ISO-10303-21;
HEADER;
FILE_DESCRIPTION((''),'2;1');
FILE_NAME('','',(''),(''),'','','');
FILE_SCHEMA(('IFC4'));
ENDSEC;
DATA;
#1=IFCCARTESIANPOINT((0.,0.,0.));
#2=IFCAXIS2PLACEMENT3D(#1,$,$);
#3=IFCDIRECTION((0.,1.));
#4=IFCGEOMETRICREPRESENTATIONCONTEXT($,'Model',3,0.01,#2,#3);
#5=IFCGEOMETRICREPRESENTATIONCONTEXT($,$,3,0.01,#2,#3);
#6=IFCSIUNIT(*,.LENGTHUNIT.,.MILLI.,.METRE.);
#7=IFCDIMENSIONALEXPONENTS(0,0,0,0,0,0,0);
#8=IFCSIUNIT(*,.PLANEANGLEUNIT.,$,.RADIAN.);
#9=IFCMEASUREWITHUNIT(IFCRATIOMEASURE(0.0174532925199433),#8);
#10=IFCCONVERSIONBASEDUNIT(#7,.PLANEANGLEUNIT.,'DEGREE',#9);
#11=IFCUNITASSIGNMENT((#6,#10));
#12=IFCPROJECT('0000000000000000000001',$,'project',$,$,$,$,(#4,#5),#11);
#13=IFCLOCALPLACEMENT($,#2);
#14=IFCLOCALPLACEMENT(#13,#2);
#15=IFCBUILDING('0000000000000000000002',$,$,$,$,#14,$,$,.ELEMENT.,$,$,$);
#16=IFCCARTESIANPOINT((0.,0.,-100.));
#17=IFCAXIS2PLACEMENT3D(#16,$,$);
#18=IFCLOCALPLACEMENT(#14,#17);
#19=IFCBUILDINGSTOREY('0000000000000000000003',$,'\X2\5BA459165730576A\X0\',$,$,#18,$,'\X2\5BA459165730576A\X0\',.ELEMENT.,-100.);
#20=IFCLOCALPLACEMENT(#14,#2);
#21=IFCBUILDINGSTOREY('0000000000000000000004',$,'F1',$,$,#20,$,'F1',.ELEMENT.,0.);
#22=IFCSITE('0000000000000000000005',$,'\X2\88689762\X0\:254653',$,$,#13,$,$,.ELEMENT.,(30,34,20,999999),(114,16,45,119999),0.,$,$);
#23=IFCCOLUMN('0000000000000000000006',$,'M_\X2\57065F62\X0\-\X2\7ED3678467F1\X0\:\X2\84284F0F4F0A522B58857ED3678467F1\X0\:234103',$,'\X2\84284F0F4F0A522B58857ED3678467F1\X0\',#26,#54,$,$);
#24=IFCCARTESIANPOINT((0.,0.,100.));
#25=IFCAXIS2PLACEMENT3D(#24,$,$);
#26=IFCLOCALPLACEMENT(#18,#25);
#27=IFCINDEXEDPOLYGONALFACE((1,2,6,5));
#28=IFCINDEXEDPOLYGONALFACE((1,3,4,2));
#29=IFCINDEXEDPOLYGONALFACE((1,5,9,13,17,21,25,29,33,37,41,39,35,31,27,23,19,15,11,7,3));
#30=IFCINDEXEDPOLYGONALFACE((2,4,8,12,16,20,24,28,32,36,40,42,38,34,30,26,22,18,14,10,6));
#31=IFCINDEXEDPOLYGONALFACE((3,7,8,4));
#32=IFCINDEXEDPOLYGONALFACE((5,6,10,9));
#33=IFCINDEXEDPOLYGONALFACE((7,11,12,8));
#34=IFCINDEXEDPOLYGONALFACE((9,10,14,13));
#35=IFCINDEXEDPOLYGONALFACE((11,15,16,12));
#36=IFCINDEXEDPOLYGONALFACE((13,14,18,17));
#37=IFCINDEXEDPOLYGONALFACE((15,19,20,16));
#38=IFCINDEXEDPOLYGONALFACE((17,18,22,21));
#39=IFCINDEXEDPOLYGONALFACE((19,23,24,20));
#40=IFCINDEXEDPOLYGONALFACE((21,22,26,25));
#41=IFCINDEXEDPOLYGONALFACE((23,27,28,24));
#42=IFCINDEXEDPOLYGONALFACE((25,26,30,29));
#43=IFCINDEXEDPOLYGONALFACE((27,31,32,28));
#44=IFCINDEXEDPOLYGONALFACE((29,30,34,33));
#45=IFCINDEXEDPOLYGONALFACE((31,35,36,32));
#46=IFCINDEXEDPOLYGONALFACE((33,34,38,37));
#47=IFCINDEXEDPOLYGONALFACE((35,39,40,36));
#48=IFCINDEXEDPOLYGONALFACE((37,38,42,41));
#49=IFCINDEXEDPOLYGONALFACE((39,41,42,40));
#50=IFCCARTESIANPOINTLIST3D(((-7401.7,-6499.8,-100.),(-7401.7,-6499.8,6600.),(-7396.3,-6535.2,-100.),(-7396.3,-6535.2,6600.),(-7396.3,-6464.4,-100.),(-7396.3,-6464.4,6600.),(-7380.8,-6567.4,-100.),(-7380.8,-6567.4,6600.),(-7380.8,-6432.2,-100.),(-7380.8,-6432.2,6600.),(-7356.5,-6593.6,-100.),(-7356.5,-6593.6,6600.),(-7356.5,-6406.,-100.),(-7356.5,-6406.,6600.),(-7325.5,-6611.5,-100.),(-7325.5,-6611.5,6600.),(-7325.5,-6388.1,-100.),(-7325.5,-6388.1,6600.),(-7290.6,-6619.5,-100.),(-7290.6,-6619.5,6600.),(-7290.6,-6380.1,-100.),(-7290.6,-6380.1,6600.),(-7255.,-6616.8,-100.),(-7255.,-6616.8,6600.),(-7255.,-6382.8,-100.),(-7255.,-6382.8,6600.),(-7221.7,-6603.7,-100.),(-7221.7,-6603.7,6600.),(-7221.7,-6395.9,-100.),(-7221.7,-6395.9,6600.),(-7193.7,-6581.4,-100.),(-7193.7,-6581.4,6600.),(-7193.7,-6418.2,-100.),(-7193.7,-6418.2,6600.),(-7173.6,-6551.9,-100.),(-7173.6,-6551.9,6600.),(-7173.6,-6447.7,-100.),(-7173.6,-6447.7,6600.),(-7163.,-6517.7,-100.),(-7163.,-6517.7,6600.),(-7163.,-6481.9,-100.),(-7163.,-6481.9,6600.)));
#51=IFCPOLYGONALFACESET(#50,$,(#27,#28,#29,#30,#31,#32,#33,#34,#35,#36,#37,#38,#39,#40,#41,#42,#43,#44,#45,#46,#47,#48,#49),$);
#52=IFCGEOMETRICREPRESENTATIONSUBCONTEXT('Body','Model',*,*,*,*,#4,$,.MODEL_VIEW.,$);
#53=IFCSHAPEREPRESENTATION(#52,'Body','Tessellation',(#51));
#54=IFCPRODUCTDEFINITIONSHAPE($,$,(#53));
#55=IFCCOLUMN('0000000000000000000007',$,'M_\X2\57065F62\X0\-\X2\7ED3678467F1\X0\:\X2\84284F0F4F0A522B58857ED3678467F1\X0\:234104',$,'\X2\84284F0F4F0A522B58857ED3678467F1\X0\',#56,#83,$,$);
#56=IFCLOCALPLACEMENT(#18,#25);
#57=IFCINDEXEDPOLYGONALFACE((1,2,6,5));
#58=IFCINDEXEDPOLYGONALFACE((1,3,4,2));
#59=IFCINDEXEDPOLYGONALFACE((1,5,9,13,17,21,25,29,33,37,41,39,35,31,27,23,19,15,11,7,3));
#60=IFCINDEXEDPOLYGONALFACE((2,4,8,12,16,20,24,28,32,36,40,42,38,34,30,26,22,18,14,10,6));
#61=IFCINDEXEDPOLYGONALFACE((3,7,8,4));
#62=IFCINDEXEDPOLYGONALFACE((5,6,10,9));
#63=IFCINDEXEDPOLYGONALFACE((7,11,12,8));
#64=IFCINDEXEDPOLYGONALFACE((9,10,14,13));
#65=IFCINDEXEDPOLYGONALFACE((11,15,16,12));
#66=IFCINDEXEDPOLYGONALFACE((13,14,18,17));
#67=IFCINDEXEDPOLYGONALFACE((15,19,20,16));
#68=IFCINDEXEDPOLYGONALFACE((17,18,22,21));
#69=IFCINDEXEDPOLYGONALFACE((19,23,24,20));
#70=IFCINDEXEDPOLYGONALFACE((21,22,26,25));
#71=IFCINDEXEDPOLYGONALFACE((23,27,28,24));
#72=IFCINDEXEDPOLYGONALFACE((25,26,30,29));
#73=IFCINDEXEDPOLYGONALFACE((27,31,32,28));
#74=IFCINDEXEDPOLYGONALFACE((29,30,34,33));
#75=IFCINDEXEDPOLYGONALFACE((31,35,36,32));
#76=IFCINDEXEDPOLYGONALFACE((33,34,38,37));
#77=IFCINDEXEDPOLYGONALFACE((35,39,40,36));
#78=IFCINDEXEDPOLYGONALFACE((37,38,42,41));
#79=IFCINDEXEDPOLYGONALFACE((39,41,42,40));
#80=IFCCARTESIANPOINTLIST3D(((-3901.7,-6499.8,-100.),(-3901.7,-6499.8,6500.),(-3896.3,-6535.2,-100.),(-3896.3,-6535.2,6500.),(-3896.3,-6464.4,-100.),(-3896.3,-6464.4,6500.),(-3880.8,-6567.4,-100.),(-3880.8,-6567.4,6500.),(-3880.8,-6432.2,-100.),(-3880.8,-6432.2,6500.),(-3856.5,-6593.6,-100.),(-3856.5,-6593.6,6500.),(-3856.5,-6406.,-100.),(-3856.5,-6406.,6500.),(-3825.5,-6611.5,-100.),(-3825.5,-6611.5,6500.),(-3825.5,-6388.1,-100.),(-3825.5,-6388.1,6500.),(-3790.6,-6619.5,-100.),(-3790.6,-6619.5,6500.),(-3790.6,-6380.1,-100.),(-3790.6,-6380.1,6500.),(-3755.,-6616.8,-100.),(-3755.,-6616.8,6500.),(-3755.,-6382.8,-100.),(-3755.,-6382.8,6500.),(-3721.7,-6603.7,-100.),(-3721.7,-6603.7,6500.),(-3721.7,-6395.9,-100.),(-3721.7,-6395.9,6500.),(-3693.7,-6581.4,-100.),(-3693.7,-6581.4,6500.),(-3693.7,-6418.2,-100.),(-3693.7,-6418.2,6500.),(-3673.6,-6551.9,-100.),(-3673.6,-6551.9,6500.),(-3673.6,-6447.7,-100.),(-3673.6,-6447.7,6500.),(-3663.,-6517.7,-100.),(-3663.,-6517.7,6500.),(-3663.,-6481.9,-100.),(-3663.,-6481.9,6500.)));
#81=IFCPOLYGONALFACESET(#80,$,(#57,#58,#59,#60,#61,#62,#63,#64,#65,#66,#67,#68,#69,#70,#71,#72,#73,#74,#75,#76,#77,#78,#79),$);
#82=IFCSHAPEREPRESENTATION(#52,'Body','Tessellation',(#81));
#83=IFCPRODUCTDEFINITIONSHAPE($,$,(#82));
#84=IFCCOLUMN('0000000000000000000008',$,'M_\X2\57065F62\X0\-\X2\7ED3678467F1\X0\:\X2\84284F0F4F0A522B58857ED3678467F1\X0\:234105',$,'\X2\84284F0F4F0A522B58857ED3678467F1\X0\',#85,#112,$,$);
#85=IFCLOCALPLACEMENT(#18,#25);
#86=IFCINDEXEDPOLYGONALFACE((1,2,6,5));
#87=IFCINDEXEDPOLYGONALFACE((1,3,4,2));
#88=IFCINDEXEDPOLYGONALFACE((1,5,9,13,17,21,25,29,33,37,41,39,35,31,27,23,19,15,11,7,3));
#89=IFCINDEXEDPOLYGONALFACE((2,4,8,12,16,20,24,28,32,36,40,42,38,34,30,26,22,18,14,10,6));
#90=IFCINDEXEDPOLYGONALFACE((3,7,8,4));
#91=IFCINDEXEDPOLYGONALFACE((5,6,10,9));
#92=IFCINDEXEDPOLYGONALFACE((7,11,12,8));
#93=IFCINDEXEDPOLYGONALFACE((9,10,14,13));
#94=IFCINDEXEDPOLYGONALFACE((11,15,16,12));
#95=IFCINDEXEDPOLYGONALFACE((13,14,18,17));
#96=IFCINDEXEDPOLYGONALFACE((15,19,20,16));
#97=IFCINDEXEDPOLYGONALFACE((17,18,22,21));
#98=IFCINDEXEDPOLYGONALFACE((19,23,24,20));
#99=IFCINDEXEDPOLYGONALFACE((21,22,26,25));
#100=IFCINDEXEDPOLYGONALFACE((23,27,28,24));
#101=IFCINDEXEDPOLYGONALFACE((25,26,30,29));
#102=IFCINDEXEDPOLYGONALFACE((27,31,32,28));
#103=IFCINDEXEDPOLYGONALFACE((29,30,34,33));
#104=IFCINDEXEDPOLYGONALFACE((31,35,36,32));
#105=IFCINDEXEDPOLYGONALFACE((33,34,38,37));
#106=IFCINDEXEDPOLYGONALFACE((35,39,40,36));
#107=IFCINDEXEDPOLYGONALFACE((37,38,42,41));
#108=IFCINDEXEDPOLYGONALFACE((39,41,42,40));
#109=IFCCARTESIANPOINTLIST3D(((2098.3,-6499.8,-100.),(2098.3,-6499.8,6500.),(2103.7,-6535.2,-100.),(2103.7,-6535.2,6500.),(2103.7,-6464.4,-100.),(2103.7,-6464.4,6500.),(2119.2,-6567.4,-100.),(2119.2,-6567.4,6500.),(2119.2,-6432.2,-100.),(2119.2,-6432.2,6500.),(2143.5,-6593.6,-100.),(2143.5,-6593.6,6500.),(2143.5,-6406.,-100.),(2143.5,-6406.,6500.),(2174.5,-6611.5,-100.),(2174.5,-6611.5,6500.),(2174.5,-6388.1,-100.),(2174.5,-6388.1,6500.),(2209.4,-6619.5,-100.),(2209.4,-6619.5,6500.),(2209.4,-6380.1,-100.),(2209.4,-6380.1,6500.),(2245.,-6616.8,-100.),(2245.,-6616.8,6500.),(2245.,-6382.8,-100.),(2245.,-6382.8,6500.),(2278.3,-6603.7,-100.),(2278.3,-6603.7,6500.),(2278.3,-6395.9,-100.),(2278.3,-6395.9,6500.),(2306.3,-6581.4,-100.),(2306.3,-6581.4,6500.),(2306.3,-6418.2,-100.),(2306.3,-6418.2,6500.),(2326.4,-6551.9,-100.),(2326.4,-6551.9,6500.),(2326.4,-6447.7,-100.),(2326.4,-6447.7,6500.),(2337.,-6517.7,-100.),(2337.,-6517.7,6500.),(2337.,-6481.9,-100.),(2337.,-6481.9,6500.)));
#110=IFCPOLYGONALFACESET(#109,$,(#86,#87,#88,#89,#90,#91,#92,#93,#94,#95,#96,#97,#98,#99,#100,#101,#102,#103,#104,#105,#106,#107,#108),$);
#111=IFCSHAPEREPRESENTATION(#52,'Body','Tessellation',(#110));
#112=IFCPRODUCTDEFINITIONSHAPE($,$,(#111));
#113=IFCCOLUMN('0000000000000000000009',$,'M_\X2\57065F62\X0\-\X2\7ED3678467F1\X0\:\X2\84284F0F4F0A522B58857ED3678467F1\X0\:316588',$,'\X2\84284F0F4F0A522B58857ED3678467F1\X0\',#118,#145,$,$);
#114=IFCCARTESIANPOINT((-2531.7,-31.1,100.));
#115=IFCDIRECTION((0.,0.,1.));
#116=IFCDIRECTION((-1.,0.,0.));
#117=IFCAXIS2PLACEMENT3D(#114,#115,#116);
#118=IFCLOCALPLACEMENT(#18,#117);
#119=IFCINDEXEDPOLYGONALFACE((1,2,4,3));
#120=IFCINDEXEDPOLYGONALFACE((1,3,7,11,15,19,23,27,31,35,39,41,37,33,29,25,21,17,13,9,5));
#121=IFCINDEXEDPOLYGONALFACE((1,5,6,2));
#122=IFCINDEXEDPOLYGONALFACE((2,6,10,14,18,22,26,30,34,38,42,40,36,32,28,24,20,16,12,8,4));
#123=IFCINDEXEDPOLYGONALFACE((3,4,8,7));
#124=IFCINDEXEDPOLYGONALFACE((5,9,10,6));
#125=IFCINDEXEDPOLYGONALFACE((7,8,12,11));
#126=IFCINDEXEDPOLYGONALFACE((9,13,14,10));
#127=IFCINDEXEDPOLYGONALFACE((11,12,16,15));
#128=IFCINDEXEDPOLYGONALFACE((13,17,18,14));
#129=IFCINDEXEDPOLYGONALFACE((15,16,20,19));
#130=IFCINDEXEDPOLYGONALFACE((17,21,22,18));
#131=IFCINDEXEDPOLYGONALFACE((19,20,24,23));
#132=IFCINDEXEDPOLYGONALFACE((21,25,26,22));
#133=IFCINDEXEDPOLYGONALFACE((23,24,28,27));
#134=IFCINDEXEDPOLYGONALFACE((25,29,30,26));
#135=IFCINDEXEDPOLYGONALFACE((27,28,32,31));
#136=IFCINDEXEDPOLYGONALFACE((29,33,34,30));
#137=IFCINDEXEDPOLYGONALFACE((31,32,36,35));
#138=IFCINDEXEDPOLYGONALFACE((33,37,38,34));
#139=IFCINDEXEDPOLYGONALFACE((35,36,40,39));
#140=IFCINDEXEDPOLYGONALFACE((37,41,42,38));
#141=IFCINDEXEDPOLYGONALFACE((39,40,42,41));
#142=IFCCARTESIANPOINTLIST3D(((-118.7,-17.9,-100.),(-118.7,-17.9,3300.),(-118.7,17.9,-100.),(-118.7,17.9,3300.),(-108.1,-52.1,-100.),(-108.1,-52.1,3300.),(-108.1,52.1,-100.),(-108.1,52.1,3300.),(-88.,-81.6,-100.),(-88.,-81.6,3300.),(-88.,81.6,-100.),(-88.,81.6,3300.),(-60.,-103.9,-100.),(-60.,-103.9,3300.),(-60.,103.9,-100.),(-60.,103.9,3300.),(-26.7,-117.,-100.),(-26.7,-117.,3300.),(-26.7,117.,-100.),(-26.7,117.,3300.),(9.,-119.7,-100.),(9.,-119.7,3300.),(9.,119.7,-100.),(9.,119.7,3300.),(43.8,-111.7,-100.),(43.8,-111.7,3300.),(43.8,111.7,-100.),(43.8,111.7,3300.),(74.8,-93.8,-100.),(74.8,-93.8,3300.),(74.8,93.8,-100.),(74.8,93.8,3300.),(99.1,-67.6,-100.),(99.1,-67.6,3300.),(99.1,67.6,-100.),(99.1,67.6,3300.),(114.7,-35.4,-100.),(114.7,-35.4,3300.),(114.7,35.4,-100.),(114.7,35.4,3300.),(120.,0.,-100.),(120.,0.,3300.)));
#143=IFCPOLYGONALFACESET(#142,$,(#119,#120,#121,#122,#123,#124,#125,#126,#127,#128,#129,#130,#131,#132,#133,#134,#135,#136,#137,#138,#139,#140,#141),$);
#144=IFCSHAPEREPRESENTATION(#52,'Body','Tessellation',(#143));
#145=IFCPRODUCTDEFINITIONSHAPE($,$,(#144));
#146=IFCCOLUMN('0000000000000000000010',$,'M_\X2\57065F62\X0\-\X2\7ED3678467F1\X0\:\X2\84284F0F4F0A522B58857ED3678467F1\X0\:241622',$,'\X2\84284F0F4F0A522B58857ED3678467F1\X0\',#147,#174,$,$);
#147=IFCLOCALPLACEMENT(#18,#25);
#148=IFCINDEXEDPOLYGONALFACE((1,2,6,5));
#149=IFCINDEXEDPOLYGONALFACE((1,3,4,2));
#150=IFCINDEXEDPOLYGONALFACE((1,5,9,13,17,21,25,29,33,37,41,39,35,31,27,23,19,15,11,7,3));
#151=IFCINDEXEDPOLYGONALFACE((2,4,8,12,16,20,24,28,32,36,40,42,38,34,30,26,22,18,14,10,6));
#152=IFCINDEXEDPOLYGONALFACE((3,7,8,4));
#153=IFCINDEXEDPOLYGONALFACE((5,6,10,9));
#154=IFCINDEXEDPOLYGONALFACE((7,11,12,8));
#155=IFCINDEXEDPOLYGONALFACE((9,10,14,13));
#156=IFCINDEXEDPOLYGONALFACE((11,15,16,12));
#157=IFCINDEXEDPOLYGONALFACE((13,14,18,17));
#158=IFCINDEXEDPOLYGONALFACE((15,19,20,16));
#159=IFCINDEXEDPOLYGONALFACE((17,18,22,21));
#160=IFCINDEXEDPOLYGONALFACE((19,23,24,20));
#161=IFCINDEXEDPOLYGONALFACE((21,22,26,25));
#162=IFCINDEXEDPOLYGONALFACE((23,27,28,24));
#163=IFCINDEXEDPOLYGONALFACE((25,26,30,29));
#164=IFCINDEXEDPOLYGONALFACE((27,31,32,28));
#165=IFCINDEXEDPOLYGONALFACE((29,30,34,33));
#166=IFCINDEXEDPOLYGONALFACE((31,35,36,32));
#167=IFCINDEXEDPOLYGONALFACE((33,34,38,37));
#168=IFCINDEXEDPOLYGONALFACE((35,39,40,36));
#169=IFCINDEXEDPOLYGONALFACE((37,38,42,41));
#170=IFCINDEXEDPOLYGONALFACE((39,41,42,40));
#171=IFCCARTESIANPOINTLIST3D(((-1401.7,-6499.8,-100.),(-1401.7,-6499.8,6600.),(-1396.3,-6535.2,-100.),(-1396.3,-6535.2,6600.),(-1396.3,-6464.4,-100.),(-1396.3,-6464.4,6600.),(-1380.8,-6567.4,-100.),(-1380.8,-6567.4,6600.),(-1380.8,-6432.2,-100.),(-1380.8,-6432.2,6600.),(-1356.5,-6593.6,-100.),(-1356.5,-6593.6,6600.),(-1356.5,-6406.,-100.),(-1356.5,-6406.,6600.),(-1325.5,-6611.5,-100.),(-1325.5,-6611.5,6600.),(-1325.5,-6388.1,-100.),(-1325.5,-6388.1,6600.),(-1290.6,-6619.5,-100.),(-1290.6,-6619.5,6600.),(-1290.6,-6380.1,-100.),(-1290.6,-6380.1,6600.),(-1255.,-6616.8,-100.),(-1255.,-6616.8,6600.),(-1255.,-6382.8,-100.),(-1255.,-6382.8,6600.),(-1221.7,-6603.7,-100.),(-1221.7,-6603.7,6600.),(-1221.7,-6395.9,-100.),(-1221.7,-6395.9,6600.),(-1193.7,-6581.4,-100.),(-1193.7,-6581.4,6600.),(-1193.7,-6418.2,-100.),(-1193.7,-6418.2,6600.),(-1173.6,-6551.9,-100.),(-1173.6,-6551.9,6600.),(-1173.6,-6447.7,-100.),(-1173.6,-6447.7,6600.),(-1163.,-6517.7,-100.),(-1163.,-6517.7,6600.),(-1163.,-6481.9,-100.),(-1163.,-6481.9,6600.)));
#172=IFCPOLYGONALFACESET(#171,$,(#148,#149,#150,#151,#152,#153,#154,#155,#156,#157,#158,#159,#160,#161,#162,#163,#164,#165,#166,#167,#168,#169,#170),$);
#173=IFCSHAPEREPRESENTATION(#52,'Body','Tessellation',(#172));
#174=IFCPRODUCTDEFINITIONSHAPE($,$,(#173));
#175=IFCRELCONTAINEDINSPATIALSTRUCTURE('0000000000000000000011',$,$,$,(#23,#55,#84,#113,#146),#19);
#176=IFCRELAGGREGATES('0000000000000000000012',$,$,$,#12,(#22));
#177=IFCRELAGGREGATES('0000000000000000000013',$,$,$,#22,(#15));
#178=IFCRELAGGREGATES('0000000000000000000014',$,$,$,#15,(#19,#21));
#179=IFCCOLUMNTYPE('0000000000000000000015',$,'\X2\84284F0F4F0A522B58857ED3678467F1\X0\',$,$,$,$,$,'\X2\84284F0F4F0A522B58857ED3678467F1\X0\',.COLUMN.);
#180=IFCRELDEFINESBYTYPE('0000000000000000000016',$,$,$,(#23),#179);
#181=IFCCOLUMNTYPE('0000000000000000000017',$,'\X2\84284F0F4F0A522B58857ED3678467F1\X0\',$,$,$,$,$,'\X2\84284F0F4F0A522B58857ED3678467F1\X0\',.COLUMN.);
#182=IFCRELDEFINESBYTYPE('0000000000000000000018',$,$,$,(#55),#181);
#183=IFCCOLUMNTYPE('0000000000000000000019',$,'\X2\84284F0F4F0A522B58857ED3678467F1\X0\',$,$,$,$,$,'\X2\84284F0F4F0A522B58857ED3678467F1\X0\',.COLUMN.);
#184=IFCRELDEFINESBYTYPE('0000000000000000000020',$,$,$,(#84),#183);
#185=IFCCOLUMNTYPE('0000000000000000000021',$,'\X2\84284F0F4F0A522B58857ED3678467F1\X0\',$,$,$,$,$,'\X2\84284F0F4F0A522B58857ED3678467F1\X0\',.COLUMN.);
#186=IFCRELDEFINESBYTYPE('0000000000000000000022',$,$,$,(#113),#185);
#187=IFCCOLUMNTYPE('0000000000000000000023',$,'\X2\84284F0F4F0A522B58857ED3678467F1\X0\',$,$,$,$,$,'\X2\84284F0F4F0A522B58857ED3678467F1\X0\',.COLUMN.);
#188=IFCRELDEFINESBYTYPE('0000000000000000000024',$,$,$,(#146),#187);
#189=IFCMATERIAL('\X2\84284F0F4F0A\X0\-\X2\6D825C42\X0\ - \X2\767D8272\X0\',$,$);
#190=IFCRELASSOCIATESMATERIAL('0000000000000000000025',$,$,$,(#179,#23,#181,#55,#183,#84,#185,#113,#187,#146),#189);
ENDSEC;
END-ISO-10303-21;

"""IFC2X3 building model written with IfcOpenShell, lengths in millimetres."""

from ifc_helpers import new_model, entity, si_unit, converted_unit, direction, frame, frame_2d, origin, origin_2d_with_axis, place, context, subcontext, project, spatial, circle, extrude, source, transform, mapped, material, type_object, type_shapes, element, save


model = new_model("IFC2X3")

# Units and contexts
model_context = context("Model", 3, precision=0.01, world=origin(), true_north=direction((0.0, 1.0)))
context_of_model = context(None, 3, precision=0.01, world=origin(), true_north=direction((0.0, 1.0)))
body_context = subcontext(model_context, "Body", "Model", "MODEL_VIEW")
ifc_project = project(units=[si_unit("LENGTHUNIT", "METRE", prefix="MILLI"), converted_unit("PLANEANGLEUNIT", "DEGREE", entity("IfcRatioMeasure", 0.0174532925199433), si_unit("PLANEANGLEUNIT", "RADIAN"), dimensions=[0, 0, 0, 0, 0, 0, 0])], contexts=[model_context, context_of_model])

# Site, building, storey
site_placement = place(None, origin())
site = spatial("IfcSite", under=ifc_project, at=site_placement, Name="表面:254653", CompositionType="ELEMENT", RefLatitude=(30, 34, 20, 999999), RefLongitude=(114, 16, 45, 119999), RefElevation=0.0)
building_placement = place(site_placement, origin())
building = spatial("IfcBuilding", under=site, at=building_placement, CompositionType="ELEMENT")
storey_1_placement = place(building_placement, frame((0.0, 0.0, -100.0)))
storey_1 = spatial("IfcBuildingStorey", under=building, at=storey_1_placement, Name="室外地坪", LongName="室外地坪", CompositionType="ELEMENT", Elevation=-100.0)

# Columns
ifc_material_1 = material(Name="萨伏伊-涂层 - 白色")
column_type_1 = type_object("IfcColumnType", Name="萨伏伊别墅结构柱", ElementType="萨伏伊别墅结构柱", PredefinedType="COLUMN", material=ifc_material_1)
shared_shape_1 = source(origin(), body_context, "Body", "SweptSolid", [
    extrude(circle(Radius=120.0, at=origin_2d_with_axis()), frame((-7281.7, -6499.8, -100.0), z_axis=(0.0, 0.0, 1.0), x_axis=(-1.0, 0.0, 0.0)), (0.0, 0.0, 1.0), 6700.0),
])
type_shapes(column_type_1, [shared_shape_1])
column_1_placement = place(storey_1_placement, frame((0.0, 0.0, 100.0)))
element("IfcColumn", 1, at=column_1_placement, inside=storey_1, type_object=column_type_1, material=ifc_material_1, Name="M_圆形-结构柱:萨伏伊别墅结构柱:234103", ObjectType="萨伏伊别墅结构柱", context=body_context, shape_type="MappedRepresentation", body=[
    mapped(shared_shape_1, transform((0.0, 0.0, 0.0), scale=1.0)),
])
column_type_2 = type_object("IfcColumnType", Name="萨伏伊别墅结构柱", ElementType="萨伏伊别墅结构柱", PredefinedType="COLUMN", material=ifc_material_1)
shared_shape_2 = source(origin(), body_context, "Body", "SweptSolid", [
    extrude(circle(Radius=120.0, at=origin_2d_with_axis()), frame((-3781.7, -6499.8, -100.0), z_axis=(0.0, 0.0, 1.0), x_axis=(-1.0, 0.0, 0.0)), (0.0, 0.0, 1.0), 6600.0),
])
type_shapes(column_type_2, [shared_shape_2])
column_2_placement = place(storey_1_placement, frame((0.0, 0.0, 100.0)))
element("IfcColumn", 2, at=column_2_placement, inside=storey_1, type_object=column_type_2, material=ifc_material_1, Name="M_圆形-结构柱:萨伏伊别墅结构柱:234104", ObjectType="萨伏伊别墅结构柱", context=body_context, shape_type="MappedRepresentation", body=[
    mapped(shared_shape_2, transform((0.0, 0.0, 0.0), scale=1.0)),
])
column_type_3 = type_object("IfcColumnType", Name="萨伏伊别墅结构柱", ElementType="萨伏伊别墅结构柱", PredefinedType="COLUMN", material=ifc_material_1)
shared_shape_3 = source(origin(), body_context, "Body", "SweptSolid", [
    extrude(circle(Radius=120.0, at=origin_2d_with_axis()), frame((2218.3, -6499.8, -100.0), z_axis=(0.0, 0.0, 1.0), x_axis=(-1.0, 0.0, 0.0)), (0.0, 0.0, 1.0), 6600.0),
])
type_shapes(column_type_3, [shared_shape_3])
column_3_placement = place(storey_1_placement, frame((0.0, 0.0, 100.0)))
element("IfcColumn", 3, at=column_3_placement, inside=storey_1, type_object=column_type_3, material=ifc_material_1, Name="M_圆形-结构柱:萨伏伊别墅结构柱:234105", ObjectType="萨伏伊别墅结构柱", context=body_context, shape_type="MappedRepresentation", body=[
    mapped(shared_shape_3, transform((0.0, 0.0, 0.0), scale=1.0)),
])
column_type_4 = type_object("IfcColumnType", Name="萨伏伊别墅结构柱", ElementType="萨伏伊别墅结构柱", PredefinedType="COLUMN", material=ifc_material_1)
shared_shape_4 = source(origin(), body_context, "Body", "SweptSolid", [
    extrude(circle(Radius=120.0, at=frame_2d((0.0, 0.0), x_axis=(1.0, 0.0))), frame((0.0, 0.0, -100.0)), (0.0, 0.0, 1.0), 3400.0),
])
type_shapes(column_type_4, [shared_shape_4])
column_4_placement = place(storey_1_placement, frame((-2531.7, -31.1, 100.0), z_axis=(0.0, 0.0, 1.0), x_axis=(-1.0, 0.0, 0.0)))
element("IfcColumn", 4, at=column_4_placement, inside=storey_1, type_object=column_type_4, material=ifc_material_1, Name="M_圆形-结构柱:萨伏伊别墅结构柱:316588", ObjectType="萨伏伊别墅结构柱", context=body_context, shape_type="MappedRepresentation", body=[
    mapped(shared_shape_4, transform((0.0, 0.0, 0.0), scale=1.0)),
])
column_type_5 = type_object("IfcColumnType", Name="萨伏伊别墅结构柱", ElementType="萨伏伊别墅结构柱", PredefinedType="COLUMN", material=ifc_material_1)
shared_shape_5 = source(origin(), body_context, "Body", "SweptSolid", [
    extrude(circle(Radius=120.0, at=origin_2d_with_axis()), frame((-1281.7, -6499.8, -100.0), z_axis=(0.0, 0.0, 1.0), x_axis=(-1.0, 0.0, 0.0)), (0.0, 0.0, 1.0), 6700.0),
])
type_shapes(column_type_5, [shared_shape_5])
column_5_placement = place(storey_1_placement, frame((0.0, 0.0, 100.0)))
element("IfcColumn", 5, at=column_5_placement, inside=storey_1, type_object=column_type_5, material=ifc_material_1, Name="M_圆形-结构柱:萨伏伊别墅结构柱:241622", ObjectType="萨伏伊别墅结构柱", context=body_context, shape_type="MappedRepresentation", body=[
    mapped(shared_shape_5, transform((0.0, 0.0, 0.0), scale=1.0)),
])

# Shared definitions
storey_2_placement = place(building_placement, origin())
storey_2 = spatial("IfcBuildingStorey", under=building, at=storey_2_placement, Name="F1", LongName="F1", CompositionType="ELEMENT", Elevation=0.0)

save(model, "model.ifc")
